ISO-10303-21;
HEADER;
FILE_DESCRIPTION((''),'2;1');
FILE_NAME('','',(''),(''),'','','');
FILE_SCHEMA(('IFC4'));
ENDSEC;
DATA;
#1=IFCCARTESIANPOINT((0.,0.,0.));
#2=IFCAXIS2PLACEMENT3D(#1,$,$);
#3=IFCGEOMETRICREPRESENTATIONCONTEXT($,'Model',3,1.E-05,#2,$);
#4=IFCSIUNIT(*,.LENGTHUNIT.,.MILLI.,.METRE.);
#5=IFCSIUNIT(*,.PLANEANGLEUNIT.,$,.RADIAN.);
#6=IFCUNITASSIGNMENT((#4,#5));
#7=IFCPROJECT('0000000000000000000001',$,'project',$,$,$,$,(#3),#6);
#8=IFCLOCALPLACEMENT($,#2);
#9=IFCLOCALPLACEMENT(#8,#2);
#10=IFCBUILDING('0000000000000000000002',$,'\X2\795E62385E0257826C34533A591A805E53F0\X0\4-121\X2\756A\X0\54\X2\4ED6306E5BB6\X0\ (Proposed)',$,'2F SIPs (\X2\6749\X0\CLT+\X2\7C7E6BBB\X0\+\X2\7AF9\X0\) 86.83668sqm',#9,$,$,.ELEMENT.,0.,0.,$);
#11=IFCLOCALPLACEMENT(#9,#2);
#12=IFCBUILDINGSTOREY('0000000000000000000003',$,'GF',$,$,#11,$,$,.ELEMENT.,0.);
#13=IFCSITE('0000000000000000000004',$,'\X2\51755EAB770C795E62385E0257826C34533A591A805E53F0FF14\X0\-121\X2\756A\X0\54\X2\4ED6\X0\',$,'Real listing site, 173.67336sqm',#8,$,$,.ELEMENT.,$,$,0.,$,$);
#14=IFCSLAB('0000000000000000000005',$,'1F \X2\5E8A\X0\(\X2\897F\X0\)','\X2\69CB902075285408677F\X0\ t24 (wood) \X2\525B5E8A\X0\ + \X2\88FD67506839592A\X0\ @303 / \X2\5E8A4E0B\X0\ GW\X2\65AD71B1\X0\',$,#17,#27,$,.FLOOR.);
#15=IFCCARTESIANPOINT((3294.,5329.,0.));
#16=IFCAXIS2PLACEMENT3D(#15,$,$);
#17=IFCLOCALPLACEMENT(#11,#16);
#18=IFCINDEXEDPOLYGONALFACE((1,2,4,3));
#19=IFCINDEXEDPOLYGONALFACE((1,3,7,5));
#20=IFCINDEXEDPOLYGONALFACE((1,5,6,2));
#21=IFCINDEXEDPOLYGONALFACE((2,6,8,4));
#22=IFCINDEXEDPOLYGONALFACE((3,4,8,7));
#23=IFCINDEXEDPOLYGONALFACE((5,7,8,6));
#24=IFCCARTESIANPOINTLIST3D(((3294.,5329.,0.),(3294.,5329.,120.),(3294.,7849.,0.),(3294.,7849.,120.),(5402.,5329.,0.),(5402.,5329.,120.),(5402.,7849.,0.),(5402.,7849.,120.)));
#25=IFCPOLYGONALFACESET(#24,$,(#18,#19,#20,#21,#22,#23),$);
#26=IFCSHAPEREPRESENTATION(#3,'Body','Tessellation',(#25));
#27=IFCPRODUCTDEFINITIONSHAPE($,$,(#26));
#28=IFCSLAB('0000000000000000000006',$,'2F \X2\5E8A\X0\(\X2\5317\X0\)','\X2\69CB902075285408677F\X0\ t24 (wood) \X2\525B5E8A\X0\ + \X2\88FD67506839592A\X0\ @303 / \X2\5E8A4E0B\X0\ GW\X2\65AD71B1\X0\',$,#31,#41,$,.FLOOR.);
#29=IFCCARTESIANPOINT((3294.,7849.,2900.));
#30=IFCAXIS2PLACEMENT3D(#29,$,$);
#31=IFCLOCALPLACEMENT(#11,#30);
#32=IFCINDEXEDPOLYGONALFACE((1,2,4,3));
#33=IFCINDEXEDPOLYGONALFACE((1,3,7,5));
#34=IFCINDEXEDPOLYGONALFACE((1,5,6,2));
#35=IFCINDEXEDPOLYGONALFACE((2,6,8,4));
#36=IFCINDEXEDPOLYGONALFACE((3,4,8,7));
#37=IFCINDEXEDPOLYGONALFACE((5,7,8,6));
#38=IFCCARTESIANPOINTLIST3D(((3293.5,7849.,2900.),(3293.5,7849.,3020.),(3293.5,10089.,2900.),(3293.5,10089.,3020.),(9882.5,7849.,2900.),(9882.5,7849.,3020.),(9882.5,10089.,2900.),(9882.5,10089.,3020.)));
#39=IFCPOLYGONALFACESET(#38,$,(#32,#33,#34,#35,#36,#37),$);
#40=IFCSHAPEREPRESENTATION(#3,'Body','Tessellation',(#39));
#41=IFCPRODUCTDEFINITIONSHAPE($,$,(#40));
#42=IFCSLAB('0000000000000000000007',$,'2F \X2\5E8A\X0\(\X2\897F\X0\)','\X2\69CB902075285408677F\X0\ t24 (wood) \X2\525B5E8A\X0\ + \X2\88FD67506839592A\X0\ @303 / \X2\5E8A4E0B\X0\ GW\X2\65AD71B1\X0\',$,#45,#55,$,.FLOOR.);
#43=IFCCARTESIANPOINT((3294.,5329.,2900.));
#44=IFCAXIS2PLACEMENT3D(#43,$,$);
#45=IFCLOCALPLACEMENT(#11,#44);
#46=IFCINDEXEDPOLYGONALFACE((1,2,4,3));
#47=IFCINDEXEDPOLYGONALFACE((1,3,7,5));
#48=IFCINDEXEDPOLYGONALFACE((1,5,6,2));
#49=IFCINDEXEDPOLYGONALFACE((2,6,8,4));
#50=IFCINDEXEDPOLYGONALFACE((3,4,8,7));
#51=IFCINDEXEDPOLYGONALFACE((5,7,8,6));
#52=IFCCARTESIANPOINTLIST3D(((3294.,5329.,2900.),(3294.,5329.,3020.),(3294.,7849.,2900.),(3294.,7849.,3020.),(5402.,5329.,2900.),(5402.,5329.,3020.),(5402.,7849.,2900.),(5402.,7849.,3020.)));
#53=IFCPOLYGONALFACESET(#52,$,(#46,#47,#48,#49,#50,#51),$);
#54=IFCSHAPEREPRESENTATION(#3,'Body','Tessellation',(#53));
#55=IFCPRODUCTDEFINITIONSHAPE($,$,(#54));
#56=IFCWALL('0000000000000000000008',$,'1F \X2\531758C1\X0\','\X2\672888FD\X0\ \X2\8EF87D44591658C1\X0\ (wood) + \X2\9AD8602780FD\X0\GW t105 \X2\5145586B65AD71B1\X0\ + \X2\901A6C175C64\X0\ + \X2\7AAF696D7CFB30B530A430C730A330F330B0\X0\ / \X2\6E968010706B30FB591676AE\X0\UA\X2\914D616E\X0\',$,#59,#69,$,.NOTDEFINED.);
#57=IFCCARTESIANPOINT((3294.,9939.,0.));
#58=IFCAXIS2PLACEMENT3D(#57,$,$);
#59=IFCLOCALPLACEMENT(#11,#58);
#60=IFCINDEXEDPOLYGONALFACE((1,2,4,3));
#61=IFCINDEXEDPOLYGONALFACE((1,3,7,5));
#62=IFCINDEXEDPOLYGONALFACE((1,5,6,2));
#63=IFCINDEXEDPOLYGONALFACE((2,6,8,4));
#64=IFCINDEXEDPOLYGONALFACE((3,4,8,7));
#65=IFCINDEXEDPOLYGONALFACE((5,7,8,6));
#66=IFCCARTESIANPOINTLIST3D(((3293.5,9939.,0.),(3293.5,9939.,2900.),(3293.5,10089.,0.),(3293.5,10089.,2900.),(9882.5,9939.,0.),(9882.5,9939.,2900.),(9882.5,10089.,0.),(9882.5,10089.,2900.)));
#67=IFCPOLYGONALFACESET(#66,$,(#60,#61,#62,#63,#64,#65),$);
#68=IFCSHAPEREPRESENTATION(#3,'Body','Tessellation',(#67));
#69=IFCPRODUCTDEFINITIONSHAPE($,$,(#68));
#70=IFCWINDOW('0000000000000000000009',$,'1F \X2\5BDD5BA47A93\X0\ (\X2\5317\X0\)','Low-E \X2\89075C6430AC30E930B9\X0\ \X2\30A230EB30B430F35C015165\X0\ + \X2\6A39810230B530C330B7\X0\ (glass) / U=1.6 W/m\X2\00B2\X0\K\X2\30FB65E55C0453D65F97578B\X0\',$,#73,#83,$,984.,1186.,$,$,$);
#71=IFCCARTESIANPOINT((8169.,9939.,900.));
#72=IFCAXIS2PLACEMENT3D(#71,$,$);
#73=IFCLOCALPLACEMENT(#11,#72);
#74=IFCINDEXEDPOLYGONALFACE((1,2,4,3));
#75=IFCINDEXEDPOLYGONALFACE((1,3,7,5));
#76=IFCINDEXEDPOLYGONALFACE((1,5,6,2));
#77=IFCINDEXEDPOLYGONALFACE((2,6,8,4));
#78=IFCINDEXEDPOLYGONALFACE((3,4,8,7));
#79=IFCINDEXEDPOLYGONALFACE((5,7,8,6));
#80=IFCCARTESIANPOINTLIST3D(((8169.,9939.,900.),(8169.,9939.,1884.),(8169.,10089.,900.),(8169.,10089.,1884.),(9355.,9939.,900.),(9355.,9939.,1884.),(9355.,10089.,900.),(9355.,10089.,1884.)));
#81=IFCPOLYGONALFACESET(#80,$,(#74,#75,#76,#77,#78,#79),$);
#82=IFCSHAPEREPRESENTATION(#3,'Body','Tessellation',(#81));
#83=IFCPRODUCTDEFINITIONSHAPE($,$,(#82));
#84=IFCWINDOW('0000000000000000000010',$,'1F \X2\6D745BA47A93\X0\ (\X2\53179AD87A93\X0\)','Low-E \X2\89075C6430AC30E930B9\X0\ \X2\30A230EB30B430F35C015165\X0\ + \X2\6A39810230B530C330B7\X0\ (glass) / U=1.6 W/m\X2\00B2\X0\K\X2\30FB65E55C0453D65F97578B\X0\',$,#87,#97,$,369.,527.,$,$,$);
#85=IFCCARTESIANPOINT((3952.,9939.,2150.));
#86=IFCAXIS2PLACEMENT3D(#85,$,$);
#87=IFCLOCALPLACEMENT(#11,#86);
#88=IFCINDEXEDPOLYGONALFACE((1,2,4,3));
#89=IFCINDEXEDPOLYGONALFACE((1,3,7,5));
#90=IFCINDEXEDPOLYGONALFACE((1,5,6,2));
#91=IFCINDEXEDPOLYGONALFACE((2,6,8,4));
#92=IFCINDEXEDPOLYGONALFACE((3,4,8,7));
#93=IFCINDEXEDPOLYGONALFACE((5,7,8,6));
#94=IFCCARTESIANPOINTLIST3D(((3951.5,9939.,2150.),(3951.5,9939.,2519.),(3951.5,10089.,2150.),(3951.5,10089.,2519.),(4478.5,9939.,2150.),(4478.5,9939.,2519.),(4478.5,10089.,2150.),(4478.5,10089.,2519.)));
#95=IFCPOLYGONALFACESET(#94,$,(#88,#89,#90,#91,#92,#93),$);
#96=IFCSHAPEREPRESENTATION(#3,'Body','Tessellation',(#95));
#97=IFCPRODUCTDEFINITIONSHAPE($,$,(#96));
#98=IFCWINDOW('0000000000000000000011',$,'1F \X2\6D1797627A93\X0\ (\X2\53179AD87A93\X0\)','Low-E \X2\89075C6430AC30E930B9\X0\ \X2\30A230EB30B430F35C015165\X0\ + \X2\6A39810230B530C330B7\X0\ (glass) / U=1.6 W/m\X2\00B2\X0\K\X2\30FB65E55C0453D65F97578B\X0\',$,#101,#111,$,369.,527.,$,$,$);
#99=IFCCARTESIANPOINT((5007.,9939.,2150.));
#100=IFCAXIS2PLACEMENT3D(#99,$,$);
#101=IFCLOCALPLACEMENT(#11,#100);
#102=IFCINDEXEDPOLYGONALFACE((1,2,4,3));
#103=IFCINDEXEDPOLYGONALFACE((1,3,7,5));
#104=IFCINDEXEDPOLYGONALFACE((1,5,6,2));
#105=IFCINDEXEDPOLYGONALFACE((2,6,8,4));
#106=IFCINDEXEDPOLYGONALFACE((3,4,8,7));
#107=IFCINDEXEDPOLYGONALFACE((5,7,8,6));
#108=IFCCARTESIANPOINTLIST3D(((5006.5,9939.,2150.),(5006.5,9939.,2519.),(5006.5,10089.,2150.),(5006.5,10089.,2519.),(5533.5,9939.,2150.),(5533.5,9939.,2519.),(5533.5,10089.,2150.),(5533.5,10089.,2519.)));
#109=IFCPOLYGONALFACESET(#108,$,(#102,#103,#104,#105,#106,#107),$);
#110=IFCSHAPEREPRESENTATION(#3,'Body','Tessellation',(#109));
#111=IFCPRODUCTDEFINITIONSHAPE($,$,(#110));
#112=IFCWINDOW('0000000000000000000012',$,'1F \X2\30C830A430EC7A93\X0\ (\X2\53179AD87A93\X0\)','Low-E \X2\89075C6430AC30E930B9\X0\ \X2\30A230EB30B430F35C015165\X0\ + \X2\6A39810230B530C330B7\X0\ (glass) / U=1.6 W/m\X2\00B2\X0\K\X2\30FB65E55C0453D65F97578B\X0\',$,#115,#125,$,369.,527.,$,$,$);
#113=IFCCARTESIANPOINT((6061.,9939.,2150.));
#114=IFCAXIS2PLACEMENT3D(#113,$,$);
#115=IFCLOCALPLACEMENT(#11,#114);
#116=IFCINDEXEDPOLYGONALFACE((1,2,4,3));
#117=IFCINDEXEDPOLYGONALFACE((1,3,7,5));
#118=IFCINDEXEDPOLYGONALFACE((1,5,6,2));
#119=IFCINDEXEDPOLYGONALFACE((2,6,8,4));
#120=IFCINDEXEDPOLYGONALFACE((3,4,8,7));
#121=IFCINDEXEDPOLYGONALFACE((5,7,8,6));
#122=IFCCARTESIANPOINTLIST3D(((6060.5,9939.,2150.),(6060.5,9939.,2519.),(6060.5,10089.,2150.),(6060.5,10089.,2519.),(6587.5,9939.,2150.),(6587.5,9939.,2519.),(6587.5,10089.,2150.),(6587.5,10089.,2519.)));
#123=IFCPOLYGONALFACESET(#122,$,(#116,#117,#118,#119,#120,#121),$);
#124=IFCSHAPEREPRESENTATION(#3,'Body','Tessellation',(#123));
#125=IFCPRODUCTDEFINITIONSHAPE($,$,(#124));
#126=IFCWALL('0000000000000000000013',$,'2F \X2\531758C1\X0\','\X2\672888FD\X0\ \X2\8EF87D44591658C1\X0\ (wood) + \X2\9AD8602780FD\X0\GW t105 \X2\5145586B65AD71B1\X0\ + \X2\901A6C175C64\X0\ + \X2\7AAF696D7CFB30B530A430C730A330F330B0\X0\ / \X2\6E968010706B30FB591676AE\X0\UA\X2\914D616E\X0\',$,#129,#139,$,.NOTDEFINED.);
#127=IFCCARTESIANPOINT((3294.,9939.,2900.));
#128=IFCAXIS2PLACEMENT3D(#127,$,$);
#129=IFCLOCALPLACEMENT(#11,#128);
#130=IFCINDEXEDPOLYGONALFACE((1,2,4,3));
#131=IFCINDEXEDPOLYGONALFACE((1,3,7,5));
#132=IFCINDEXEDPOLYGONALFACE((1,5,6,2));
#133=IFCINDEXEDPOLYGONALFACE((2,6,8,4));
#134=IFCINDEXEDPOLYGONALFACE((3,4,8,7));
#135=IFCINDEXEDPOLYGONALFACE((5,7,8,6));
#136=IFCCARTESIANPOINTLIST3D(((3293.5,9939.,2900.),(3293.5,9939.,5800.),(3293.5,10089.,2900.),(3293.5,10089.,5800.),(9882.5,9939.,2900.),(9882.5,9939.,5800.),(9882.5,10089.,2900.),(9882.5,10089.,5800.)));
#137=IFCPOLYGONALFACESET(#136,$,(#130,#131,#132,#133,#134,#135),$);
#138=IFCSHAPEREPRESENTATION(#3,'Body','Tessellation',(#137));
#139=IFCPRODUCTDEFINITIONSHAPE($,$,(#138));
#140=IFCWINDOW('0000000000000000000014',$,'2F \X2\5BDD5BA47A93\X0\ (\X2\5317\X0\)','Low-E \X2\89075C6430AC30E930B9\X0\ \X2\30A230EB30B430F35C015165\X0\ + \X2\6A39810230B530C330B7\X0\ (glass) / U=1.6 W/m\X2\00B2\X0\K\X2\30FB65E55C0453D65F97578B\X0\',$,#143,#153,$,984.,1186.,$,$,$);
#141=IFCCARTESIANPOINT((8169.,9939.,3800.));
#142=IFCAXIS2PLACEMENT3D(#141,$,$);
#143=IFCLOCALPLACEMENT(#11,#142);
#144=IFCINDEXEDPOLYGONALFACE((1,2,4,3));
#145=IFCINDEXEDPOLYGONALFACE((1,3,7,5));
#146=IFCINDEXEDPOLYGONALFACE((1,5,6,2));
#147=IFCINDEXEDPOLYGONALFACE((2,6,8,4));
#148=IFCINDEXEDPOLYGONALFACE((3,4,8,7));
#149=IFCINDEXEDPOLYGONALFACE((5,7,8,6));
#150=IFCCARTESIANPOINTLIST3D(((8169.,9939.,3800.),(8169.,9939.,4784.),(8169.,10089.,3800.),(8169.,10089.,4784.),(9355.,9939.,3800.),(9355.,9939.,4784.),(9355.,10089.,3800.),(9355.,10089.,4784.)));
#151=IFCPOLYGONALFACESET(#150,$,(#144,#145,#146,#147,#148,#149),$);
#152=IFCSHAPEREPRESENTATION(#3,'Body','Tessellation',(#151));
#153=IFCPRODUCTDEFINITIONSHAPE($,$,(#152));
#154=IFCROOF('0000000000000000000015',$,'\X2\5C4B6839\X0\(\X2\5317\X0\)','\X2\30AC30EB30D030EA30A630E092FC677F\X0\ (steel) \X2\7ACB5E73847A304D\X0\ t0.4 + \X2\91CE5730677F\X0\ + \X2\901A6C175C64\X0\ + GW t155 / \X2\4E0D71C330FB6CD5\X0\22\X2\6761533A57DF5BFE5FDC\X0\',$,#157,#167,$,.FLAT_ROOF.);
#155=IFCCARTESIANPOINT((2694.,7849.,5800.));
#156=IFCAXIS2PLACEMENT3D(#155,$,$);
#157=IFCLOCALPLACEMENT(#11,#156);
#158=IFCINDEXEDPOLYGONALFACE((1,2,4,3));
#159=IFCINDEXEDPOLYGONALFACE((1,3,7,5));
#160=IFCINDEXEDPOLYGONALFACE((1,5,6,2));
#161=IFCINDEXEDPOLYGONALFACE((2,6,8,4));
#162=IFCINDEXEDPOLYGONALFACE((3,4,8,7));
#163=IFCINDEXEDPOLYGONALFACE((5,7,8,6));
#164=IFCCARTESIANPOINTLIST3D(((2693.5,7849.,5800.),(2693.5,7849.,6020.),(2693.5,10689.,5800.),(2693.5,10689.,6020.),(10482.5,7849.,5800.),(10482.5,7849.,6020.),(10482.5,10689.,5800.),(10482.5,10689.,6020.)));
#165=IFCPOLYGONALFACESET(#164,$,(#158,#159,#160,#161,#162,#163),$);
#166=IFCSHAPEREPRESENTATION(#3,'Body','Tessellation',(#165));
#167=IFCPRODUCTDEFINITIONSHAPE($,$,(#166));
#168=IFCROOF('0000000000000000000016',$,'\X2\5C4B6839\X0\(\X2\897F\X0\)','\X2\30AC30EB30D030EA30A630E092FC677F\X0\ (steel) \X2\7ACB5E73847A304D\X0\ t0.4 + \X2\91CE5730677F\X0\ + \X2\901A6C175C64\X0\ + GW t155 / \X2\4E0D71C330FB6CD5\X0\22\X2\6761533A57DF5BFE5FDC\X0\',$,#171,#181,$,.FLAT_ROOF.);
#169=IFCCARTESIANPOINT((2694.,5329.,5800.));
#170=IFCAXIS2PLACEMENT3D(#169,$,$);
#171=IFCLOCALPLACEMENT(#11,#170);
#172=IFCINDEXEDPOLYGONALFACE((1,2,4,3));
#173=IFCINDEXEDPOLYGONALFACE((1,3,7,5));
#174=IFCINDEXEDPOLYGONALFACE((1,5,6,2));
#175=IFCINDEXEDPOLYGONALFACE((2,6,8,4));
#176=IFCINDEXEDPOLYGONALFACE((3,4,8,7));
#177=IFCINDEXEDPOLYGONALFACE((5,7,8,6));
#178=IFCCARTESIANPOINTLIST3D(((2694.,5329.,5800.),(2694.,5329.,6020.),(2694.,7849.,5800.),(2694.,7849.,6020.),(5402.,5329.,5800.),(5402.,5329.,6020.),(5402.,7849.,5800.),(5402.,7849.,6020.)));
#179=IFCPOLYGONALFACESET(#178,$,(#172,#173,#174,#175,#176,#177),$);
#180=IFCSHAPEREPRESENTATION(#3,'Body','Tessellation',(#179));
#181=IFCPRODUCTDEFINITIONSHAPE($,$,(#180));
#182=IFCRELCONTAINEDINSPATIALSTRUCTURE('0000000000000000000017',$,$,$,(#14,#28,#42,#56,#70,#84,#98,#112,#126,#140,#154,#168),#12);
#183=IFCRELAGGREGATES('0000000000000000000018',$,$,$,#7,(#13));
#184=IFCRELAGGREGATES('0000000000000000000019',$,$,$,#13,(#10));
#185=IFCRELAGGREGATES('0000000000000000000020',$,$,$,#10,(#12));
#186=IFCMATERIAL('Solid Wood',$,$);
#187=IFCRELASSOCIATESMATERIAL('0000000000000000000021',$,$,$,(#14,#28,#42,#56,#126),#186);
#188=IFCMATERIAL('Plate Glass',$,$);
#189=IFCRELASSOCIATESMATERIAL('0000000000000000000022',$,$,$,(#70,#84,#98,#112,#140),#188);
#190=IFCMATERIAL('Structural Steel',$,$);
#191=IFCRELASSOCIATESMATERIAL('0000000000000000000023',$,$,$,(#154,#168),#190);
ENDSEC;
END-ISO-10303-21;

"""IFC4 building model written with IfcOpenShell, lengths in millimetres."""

from ifc_helpers import new_model, si_unit, frame, frame_2d, origin, place, context, project, spatial, rectangle, extrude, material, element, fill, save


model = new_model("IFC4")

# Units and contexts
model_context = context("Model", 3, precision=1e-05, world=origin())
ifc_project = project(units=[si_unit("LENGTHUNIT", "METRE", prefix="MILLI"), si_unit("PLANEANGLEUNIT", "RADIAN")], contexts=[model_context])

# Site, building, storey
site_placement = place(None, origin())
site = spatial("IfcSite", under=ifc_project, at=site_placement, Name="兵庫県神戸市垂水区多聞台４-121番54他", ObjectType="Real listing site, 173.67336sqm", CompositionType="ELEMENT", RefElevation=0.0)
building_placement = place(site_placement, origin())
building = spatial("IfcBuilding", under=site, at=building_placement, Name="神戸市垂水区多聞台4-121番54他の家 (Proposed)", ObjectType="2F SIPs (杉CLT+籾殻+竹) 86.83668sqm", CompositionType="ELEMENT", ElevationOfRefHeight=0.0, ElevationOfTerrain=0.0)
storey_placement = place(building_placement, origin())
storey = spatial("IfcBuildingStorey", under=building, at=storey_placement, Name="GF", CompositionType="ELEMENT", Elevation=0.0)

# Slabs
ifc_material_1 = material(Name="Solid Wood")
slab_1_placement = place(storey_placement, frame((3294.0, 5329.0, 0.0)))
element("IfcSlab", 1, at=slab_1_placement, inside=storey, material=ifc_material_1, Name="1F 床(西)", Description="構造用合板 t24 (wood) 剛床 + 製材根太 @303 / 床下 GW断熱", PredefinedType="FLOOR", context=model_context, shape_type="SweptSolid", body=[
    extrude(rectangle(XDim=2108.0, YDim=2520.0, at=frame_2d((1054.0, 1260.0))), frame((3294.0, 5329.0, 0.0)), (0.0, 0.0, 1.0), 120.0),
])
slab_2_placement = place(storey_placement, frame((3294.0, 7849.0, 2900.0)))
element("IfcSlab", 2, at=slab_2_placement, inside=storey, material=ifc_material_1, Name="2F 床(北)", Description="構造用合板 t24 (wood) 剛床 + 製材根太 @303 / 床下 GW断熱", PredefinedType="FLOOR", context=model_context, shape_type="SweptSolid", body=[
    extrude(rectangle(XDim=6589.0, YDim=2240.0, at=frame_2d((3294.0, 1120.0))), frame((3294.0, 7849.0, 2900.0)), (0.0, 0.0, 1.0), 120.0),
])
slab_3_placement = place(storey_placement, frame((3294.0, 5329.0, 2900.0)))
element("IfcSlab", 3, at=slab_3_placement, inside=storey, material=ifc_material_1, Name="2F 床(西)", Description="構造用合板 t24 (wood) 剛床 + 製材根太 @303 / 床下 GW断熱", PredefinedType="FLOOR", context=model_context, shape_type="SweptSolid", body=[
    extrude(rectangle(XDim=2108.0, YDim=2520.0, at=frame_2d((1054.0, 1260.0))), frame((3294.0, 5329.0, 2900.0)), (0.0, 0.0, 1.0), 120.0),
])

# Wall, openings, windows
wall_1_placement = place(storey_placement, frame((3294.0, 9939.0, 0.0)))
wall_1 = element("IfcWall", 4, at=wall_1_placement, inside=storey, material=ifc_material_1, Name="1F 北壁", Description="木製 軸組外壁 (wood) + 高性能GW t105 充填断熱 + 通気層 + 窯業系サイディング / 準耐火・外皮UA配慮", PredefinedType="NOTDEFINED", context=model_context, shape_type="SweptSolid", body=[
    extrude(rectangle(XDim=6589.0, YDim=150.0, at=frame_2d((3294.0, 75.0))), frame((3294.0, 9939.0, 0.0)), (0.0, 0.0, 1.0), 2900.0),
])
opening_1_placement = place(storey_placement, frame((8169.0, 9939.0, 900.0)))
opening_1 = element("IfcOpeningElement", 5, at=opening_1_placement, cuts=wall_1, PredefinedType="NOTDEFINED", context=model_context, shape_type="SweptSolid", body=[
    extrude(rectangle(XDim=1186.0, YDim=150.0, at=frame_2d((593.0, 75.0))), frame((8169.0, 9939.0, 900.0)), (0.0, 0.0, 1.0), 984.0),
])
opening_2_placement = place(storey_placement, frame((3952.0, 9939.0, 2150.0)))
opening_2 = element("IfcOpeningElement", 6, at=opening_2_placement, cuts=wall_1, PredefinedType="NOTDEFINED", context=model_context, shape_type="SweptSolid", body=[
    extrude(rectangle(XDim=527.0, YDim=150.0, at=frame_2d((263.0, 75.0))), frame((3952.0, 9939.0, 2150.0)), (0.0, 0.0, 1.0), 369.0),
])
opening_3_placement = place(storey_placement, frame((5007.0, 9939.0, 2150.0)))
opening_3 = element("IfcOpeningElement", 7, at=opening_3_placement, cuts=wall_1, PredefinedType="NOTDEFINED", context=model_context, shape_type="SweptSolid", body=[
    extrude(rectangle(XDim=527.0, YDim=150.0, at=frame_2d((263.0, 75.0))), frame((5007.0, 9939.0, 2150.0)), (0.0, 0.0, 1.0), 369.0),
])
opening_4_placement = place(storey_placement, frame((6061.0, 9939.0, 2150.0)))
opening_4 = element("IfcOpeningElement", 8, at=opening_4_placement, cuts=wall_1, PredefinedType="NOTDEFINED", context=model_context, shape_type="SweptSolid", body=[
    extrude(rectangle(XDim=527.0, YDim=150.0, at=frame_2d((263.0, 75.0))), frame((6061.0, 9939.0, 2150.0)), (0.0, 0.0, 1.0), 369.0),
])
ifc_material_2 = material(Name="Plate Glass")
window_1_placement = place(storey_placement, frame((8169.0, 9939.0, 900.0)))
window_1 = element("IfcWindow", 9, at=window_1_placement, inside=storey, material=ifc_material_2, Name="1F 寝室窓 (北)", Description="Low-E 複層ガラス アルゴン封入 + 樹脂サッシ (glass) / U=1.6 W/m²K・日射取得型", OverallHeight=984.0, OverallWidth=1186.0, context=model_context, shape_type="SweptSolid", body=[
    extrude(rectangle(XDim=1186.0, YDim=150.0, at=frame_2d((593.0, 75.0))), frame((8169.0, 9939.0, 900.0)), (0.0, 0.0, 1.0), 984.0),
])
fill(opening_1, window_1)
window_2_placement = place(storey_placement, frame((3952.0, 9939.0, 2150.0)))
window_2 = element("IfcWindow", 10, at=window_2_placement, inside=storey, material=ifc_material_2, Name="1F 浴室窓 (北高窓)", Description="Low-E 複層ガラス アルゴン封入 + 樹脂サッシ (glass) / U=1.6 W/m²K・日射取得型", OverallHeight=369.0, OverallWidth=527.0, context=model_context, shape_type="SweptSolid", body=[
    extrude(rectangle(XDim=527.0, YDim=150.0, at=frame_2d((263.0, 75.0))), frame((3952.0, 9939.0, 2150.0)), (0.0, 0.0, 1.0), 369.0),
])
fill(opening_2, window_2)
window_3_placement = place(storey_placement, frame((5007.0, 9939.0, 2150.0)))
window_3 = element("IfcWindow", 11, at=window_3_placement, inside=storey, material=ifc_material_2, Name="1F 洗面窓 (北高窓)", Description="Low-E 複層ガラス アルゴン封入 + 樹脂サッシ (glass) / U=1.6 W/m²K・日射取得型", OverallHeight=369.0, OverallWidth=527.0, context=model_context, shape_type="SweptSolid", body=[
    extrude(rectangle(XDim=527.0, YDim=150.0, at=frame_2d((263.0, 75.0))), frame((5007.0, 9939.0, 2150.0)), (0.0, 0.0, 1.0), 369.0),
])
fill(opening_3, window_3)
window_4_placement = place(storey_placement, frame((6061.0, 9939.0, 2150.0)))
window_4 = element("IfcWindow", 12, at=window_4_placement, inside=storey, material=ifc_material_2, Name="1F トイレ窓 (北高窓)", Description="Low-E 複層ガラス アルゴン封入 + 樹脂サッシ (glass) / U=1.6 W/m²K・日射取得型", OverallHeight=369.0, OverallWidth=527.0, context=model_context, shape_type="SweptSolid", body=[
    extrude(rectangle(XDim=527.0, YDim=150.0, at=frame_2d((263.0, 75.0))), frame((6061.0, 9939.0, 2150.0)), (0.0, 0.0, 1.0), 369.0),
])
fill(opening_4, window_4)

# Wall, opening, window
wall_2_placement = place(storey_placement, frame((3294.0, 9939.0, 2900.0)))
wall_2 = element("IfcWall", 13, at=wall_2_placement, inside=storey, material=ifc_material_1, Name="2F 北壁", Description="木製 軸組外壁 (wood) + 高性能GW t105 充填断熱 + 通気層 + 窯業系サイディング / 準耐火・外皮UA配慮", PredefinedType="NOTDEFINED", context=model_context, shape_type="SweptSolid", body=[
    extrude(rectangle(XDim=6589.0, YDim=150.0, at=frame_2d((3294.0, 75.0))), frame((3294.0, 9939.0, 2900.0)), (0.0, 0.0, 1.0), 2900.0),
])
opening_5_placement = place(storey_placement, frame((8169.0, 9939.0, 3800.0)))
opening_5 = element("IfcOpeningElement", 14, at=opening_5_placement, cuts=wall_2, PredefinedType="NOTDEFINED", context=model_context, shape_type="SweptSolid", body=[
    extrude(rectangle(XDim=1186.0, YDim=150.0, at=frame_2d((593.0, 75.0))), frame((8169.0, 9939.0, 3800.0)), (0.0, 0.0, 1.0), 984.0),
])
window_5_placement = place(storey_placement, frame((8169.0, 9939.0, 3800.0)))
window_5 = element("IfcWindow", 15, at=window_5_placement, inside=storey, material=ifc_material_2, Name="2F 寝室窓 (北)", Description="Low-E 複層ガラス アルゴン封入 + 樹脂サッシ (glass) / U=1.6 W/m²K・日射取得型", OverallHeight=984.0, OverallWidth=1186.0, context=model_context, shape_type="SweptSolid", body=[
    extrude(rectangle(XDim=1186.0, YDim=150.0, at=frame_2d((593.0, 75.0))), frame((8169.0, 9939.0, 3800.0)), (0.0, 0.0, 1.0), 984.0),
])
fill(opening_5, window_5)

# Roofs
ifc_material_3 = material(Name="Structural Steel")
for number, where, name in (
    (16, (2694.0, 7849.0, 5800.0), "屋根(北)"),
):
    element("IfcRoof", number, at=place(storey_placement, frame(where)), inside=storey, material=ifc_material_3, Name=name, Description="ガルバリウム鋼板 (steel) 立平葺き t0.4 + 野地板 + 通気層 + GW t155 / 不燃・法22条区域対応", PredefinedType="FLAT_ROOF", context=model_context, shape_type="SweptSolid", body=[
        extrude(rectangle(XDim=7789.0, YDim=2840.0, at=frame_2d((3894.0, 1420.0))), frame((2694.0, 7849.0, 5800.0)), (0.0, 0.0, 1.0), 220.0),
    ])
roof_placement = place(storey_placement, frame((2694.0, 5329.0, 5800.0)))
element("IfcRoof", 17, at=roof_placement, inside=storey, material=ifc_material_3, Name="屋根(西)", Description="ガルバリウム鋼板 (steel) 立平葺き t0.4 + 野地板 + 通気層 + GW t155 / 不燃・法22条区域対応", PredefinedType="FLAT_ROOF", context=model_context, shape_type="SweptSolid", body=[
    extrude(rectangle(XDim=2708.0, YDim=2520.0, at=frame_2d((1354.0, 1260.0))), frame((2694.0, 5329.0, 5800.0)), (0.0, 0.0, 1.0), 220.0),
])

save(model, "model.ifc")
